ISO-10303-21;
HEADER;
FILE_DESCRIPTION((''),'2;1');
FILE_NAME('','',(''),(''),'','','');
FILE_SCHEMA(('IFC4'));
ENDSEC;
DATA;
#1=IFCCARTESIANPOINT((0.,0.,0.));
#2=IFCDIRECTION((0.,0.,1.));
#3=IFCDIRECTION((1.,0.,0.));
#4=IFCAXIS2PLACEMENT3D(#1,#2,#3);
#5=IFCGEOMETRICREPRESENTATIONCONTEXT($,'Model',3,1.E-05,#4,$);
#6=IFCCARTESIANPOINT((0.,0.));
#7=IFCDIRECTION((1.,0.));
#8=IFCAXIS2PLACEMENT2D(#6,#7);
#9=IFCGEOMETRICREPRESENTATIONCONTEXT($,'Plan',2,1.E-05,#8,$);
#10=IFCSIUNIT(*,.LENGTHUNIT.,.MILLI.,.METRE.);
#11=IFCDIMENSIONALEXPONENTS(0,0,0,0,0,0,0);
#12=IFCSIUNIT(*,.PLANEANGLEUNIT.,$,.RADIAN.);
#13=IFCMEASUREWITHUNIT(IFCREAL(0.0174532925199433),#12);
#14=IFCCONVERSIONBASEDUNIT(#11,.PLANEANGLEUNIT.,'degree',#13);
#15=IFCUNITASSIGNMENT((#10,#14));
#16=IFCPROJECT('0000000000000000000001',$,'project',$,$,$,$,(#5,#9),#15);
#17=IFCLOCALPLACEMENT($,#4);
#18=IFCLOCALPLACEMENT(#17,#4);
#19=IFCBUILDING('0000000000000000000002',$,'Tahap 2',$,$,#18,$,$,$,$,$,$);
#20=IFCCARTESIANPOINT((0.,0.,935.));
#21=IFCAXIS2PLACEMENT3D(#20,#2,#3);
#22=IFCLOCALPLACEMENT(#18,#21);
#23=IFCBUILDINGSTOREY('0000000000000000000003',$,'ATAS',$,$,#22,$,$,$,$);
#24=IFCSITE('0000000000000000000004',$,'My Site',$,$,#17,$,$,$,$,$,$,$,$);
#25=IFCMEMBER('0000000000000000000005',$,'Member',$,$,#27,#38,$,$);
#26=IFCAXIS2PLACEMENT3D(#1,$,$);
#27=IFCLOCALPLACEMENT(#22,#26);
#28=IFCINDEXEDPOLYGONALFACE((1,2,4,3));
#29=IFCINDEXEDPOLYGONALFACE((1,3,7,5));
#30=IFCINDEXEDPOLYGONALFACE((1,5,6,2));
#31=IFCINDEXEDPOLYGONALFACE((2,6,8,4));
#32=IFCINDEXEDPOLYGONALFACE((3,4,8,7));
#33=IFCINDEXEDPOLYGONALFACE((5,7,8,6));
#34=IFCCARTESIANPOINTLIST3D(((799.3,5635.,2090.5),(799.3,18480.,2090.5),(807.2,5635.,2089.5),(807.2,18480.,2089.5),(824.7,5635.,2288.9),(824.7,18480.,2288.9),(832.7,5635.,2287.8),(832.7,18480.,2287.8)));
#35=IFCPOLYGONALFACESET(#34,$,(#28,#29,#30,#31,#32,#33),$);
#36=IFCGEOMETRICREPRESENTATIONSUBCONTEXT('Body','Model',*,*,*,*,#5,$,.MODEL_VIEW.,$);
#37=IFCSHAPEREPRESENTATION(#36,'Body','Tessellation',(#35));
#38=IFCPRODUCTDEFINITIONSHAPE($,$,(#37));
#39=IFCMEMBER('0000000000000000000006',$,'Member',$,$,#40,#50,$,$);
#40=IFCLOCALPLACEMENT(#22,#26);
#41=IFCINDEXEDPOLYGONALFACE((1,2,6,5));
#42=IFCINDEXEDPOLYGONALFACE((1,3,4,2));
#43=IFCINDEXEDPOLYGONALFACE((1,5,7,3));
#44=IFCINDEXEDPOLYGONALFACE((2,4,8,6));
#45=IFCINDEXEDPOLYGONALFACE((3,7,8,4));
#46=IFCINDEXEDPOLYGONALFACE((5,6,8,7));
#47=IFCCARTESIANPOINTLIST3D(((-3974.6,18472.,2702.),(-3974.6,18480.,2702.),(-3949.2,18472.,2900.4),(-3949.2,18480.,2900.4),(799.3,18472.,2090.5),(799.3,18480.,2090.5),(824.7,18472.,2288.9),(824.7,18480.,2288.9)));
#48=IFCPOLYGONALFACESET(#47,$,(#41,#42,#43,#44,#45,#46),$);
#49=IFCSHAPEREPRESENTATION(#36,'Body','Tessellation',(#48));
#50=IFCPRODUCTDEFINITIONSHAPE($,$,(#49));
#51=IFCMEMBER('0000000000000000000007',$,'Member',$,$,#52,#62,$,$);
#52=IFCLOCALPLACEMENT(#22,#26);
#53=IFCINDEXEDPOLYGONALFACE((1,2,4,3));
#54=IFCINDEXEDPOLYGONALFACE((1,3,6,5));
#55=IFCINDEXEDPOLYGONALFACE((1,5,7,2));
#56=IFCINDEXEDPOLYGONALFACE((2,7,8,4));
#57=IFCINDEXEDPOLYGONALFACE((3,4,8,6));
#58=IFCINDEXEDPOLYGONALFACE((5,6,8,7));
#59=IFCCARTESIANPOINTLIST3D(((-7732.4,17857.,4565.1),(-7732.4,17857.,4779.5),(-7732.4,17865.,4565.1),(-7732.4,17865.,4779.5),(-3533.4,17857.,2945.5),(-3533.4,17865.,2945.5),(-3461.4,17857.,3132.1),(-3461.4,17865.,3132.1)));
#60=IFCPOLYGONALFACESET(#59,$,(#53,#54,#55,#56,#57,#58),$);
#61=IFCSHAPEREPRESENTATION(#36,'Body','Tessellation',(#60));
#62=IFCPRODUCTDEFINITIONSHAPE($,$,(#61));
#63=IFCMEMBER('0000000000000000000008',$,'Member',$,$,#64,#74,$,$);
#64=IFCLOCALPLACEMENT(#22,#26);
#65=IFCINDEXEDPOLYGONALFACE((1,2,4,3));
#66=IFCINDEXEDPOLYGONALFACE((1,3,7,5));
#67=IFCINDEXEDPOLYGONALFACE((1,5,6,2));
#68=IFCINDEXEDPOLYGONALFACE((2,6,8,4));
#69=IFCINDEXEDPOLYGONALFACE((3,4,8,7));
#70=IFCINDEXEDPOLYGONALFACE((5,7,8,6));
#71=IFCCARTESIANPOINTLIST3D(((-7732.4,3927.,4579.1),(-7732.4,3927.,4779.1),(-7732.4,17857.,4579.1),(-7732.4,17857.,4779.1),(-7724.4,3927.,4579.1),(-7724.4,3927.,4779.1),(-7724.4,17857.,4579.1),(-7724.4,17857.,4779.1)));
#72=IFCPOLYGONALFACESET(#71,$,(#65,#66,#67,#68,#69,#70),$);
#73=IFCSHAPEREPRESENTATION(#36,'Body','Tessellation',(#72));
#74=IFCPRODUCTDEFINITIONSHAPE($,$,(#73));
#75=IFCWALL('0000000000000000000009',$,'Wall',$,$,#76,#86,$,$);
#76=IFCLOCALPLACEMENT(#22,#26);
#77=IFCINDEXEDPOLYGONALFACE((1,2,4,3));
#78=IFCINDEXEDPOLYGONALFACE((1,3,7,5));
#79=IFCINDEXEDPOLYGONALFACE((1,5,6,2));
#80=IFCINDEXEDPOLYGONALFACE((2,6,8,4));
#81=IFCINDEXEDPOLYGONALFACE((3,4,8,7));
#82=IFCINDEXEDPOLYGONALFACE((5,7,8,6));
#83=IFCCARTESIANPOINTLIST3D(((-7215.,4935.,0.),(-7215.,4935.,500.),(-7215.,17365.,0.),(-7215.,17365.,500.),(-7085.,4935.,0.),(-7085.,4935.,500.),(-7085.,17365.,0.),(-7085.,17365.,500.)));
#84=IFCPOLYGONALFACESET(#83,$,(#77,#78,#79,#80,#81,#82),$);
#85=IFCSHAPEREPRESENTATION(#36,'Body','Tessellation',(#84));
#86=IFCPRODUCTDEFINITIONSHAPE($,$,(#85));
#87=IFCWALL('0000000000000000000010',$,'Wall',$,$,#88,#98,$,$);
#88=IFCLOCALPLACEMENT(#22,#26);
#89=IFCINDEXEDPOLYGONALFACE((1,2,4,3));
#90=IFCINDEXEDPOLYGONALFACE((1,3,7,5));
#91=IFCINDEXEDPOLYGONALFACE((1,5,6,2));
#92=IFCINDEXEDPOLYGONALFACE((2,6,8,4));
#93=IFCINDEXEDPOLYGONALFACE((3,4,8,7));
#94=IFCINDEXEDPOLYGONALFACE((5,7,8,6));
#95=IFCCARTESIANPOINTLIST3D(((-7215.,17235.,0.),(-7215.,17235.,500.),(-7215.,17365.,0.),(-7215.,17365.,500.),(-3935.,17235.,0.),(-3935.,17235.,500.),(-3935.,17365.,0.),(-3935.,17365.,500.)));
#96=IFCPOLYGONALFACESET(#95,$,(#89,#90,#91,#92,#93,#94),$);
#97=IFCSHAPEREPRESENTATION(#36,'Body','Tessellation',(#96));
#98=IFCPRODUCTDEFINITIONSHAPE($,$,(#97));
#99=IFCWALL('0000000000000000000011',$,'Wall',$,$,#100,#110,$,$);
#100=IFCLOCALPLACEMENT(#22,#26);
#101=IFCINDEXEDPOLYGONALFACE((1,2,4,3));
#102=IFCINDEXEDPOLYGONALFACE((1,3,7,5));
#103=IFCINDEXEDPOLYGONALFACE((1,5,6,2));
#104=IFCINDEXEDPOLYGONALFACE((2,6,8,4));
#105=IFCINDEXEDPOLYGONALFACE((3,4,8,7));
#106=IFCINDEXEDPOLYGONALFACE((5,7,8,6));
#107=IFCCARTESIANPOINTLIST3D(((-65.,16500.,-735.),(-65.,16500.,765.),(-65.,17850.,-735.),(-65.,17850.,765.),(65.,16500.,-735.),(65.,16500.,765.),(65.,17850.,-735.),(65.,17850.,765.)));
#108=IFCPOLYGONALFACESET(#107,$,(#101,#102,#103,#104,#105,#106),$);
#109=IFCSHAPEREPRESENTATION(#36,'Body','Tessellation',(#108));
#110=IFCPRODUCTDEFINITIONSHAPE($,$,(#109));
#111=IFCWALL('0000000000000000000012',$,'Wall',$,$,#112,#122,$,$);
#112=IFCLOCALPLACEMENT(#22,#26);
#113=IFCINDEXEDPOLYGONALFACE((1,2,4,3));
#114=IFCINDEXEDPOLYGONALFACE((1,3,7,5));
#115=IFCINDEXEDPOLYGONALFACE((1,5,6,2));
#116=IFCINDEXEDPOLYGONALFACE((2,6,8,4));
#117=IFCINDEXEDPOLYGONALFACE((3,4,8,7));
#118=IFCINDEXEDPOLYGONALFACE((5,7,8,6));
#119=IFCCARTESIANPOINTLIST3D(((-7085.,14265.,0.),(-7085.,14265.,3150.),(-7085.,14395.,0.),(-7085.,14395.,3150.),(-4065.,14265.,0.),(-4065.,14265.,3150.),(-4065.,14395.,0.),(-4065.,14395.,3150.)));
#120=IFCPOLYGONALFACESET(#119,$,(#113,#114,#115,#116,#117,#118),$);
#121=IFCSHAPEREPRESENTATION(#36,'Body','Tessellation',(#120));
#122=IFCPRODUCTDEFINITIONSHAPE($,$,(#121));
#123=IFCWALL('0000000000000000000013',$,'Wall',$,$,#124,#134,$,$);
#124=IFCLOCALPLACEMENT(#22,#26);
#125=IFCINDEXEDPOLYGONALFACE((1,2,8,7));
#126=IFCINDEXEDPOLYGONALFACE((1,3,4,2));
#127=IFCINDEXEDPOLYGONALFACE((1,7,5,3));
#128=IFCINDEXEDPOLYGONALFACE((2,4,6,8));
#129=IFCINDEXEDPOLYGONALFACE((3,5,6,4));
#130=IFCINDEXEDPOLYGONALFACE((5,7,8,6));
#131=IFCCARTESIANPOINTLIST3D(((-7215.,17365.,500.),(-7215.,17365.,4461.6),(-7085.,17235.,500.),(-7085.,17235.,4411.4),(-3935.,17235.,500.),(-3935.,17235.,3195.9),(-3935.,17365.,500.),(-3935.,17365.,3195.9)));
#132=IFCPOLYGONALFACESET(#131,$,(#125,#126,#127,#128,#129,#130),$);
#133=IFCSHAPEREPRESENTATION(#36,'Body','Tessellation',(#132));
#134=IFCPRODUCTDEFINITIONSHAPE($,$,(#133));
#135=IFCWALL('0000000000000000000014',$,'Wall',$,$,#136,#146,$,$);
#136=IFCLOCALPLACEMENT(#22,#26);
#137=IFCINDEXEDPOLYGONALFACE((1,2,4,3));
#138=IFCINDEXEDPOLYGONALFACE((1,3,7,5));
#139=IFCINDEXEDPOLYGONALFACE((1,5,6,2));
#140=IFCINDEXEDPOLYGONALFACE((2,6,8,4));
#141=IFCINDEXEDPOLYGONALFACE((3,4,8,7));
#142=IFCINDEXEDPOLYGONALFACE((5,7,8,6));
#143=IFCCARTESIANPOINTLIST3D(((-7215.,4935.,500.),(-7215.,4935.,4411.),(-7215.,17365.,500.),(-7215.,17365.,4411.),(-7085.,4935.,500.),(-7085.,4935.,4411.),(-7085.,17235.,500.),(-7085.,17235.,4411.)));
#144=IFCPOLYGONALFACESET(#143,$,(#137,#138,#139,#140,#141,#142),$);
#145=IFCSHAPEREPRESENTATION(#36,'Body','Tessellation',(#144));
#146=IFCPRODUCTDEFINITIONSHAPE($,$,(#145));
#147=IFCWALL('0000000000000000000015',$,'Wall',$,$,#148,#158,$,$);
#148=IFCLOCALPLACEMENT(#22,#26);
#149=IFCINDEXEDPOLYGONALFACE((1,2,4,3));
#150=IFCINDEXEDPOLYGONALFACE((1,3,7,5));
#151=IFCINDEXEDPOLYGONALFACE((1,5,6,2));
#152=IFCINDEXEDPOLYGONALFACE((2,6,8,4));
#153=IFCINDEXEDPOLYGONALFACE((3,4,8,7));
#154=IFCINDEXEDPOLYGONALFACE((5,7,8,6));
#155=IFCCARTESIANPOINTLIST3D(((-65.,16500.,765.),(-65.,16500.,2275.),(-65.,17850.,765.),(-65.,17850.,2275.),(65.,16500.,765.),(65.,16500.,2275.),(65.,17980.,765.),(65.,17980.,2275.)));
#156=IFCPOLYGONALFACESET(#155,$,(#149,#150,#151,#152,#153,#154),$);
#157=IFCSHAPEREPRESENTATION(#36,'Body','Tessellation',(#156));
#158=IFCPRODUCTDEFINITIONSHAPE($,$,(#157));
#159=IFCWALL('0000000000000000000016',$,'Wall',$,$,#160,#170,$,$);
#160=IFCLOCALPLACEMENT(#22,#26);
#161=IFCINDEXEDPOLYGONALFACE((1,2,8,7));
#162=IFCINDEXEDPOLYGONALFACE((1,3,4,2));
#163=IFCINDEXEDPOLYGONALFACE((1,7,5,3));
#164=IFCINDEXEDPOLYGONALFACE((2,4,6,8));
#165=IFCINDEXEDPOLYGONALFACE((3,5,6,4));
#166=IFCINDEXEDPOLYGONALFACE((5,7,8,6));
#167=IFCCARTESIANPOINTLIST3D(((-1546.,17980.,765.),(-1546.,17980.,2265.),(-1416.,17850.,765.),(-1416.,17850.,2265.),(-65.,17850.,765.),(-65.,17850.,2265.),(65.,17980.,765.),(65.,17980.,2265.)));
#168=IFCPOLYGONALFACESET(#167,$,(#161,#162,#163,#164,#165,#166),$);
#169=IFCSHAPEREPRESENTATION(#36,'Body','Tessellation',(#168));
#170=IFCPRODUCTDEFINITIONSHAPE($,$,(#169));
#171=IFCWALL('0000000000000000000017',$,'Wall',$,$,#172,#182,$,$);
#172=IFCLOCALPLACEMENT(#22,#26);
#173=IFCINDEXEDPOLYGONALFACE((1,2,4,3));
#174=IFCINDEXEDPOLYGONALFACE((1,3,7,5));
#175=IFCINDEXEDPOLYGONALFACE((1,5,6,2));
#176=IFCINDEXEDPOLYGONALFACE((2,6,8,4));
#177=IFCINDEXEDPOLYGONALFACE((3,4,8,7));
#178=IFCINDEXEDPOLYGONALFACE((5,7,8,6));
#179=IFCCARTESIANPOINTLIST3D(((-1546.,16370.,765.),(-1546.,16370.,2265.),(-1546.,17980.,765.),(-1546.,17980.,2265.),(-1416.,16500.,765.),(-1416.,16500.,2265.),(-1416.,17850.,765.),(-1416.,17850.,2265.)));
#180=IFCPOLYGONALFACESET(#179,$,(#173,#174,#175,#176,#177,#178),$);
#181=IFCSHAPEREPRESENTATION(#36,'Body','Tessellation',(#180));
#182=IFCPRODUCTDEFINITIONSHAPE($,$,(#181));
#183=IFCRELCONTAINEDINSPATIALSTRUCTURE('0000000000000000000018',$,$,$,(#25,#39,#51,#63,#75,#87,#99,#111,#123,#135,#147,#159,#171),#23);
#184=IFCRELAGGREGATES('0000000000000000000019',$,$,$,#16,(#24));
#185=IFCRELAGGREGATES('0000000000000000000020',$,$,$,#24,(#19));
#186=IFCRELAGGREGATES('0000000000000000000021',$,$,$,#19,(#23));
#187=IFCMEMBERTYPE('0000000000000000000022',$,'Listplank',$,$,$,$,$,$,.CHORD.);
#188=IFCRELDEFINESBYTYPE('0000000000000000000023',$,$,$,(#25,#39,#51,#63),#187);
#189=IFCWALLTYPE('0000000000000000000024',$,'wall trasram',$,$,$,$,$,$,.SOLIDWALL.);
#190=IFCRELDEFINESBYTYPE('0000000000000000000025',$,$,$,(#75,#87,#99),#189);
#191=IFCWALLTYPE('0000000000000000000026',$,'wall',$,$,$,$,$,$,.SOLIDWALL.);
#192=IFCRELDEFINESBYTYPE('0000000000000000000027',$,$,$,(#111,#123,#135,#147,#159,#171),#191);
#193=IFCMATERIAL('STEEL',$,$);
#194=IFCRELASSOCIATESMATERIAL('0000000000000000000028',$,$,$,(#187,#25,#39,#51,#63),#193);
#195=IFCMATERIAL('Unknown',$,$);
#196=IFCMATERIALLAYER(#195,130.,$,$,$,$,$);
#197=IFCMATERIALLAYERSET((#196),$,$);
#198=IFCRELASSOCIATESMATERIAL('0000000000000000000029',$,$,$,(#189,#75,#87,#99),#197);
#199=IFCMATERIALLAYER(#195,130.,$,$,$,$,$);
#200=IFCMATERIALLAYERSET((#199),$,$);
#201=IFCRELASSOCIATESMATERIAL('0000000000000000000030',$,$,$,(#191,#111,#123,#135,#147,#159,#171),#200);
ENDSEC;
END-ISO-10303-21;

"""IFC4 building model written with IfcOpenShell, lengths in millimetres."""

from ifc_helpers import new_model, entity, si_unit, converted_unit, frame, origin_with_axes, origin_2d_with_axis, place, context, subcontext, project, spatial, line, indexed_curve, rectangle, outline, extrude, clip, halfspace, material, layer, layer_set, layer_usage, material_profile, profile_set, profile_usage, type_object, element, save


model = new_model("IFC4")

# Units and contexts
model_context = context("Model", 3, precision=1e-05, world=origin_with_axes())
plan_context = context("Plan", 2, precision=1e-05, world=origin_2d_with_axis())
body_context_1 = subcontext(model_context, "Body", "Model", "MODEL_VIEW")
ifc_project = project(units=[si_unit("LENGTHUNIT", "METRE", prefix="MILLI"), converted_unit("PLANEANGLEUNIT", "degree", entity("IfcReal", 0.0174532925199433), si_unit("PLANEANGLEUNIT", "RADIAN"), dimensions=[0, 0, 0, 0, 0, 0, 0])], contexts=[model_context, plan_context])

# Site, building, storey
site_placement = place(None, origin_with_axes())
site = spatial("IfcSite", under=ifc_project, at=site_placement, Name="My Site")
building_placement = place(site_placement, origin_with_axes())
building = spatial("IfcBuilding", under=site, at=building_placement, Name="Tahap 2")
storey_placement = place(building_placement, frame((0.0, 0.0, 935.0), z_axis=(0.0, 0.0, 1.0), x_axis=(1.0, 0.0, 0.0)))
storey = spatial("IfcBuildingStorey", under=building, at=storey_placement, Name="ATAS")

# Members
ifc_material_1 = material(Name="STEEL")
ifc_material_profile = material_profile(ifc_material_1, rectangle(XDim=8.0, YDim=200.0, kind="CURVE"))
ifc_profile_set = profile_set([ifc_material_profile])
ifc_profile_usage_1 = profile_usage(ifc_profile_set, cardinal=9)
member_type = type_object("IfcMemberType", Name="Listplank", PredefinedType="CHORD", material=ifc_profile_set)
member_1_placement = place(storey_placement, frame((824.7, 18480.0, 2288.9), z_axis=(0.0, -1.0, 0.0), x_axis=(0.991894, 0.0, -0.127067)))
element("IfcMember", 1, at=member_1_placement, inside=storey, type_object=member_type, material=ifc_profile_usage_1, Name="Member", context=body_context_1, shape_type="SweptSolid", body=[
    extrude(rectangle(XDim=8.0, YDim=200.0, kind="CURVE"), frame((4.0, -100.0, 0.0), z_axis=(0.0, 0.0, 1.0), x_axis=(1.0, 0.0, 0.0)), (0.0, 0.0, 1.0), 12845.0),
])
ifc_profile_usage_2 = profile_usage(ifc_profile_set, cardinal=9)
member_2_placement = place(storey_placement, frame((824.7, 18480.0, 2288.9), z_axis=(-0.991894, 0.0, 0.127065), x_axis=(0.0, -1.0, 0.0)))
element("IfcMember", 2, at=member_2_placement, inside=storey, type_object=member_type, material=ifc_profile_usage_2, Name="Member", context=body_context_1, shape_type="SweptSolid", body=[
    extrude(rectangle(XDim=8.0, YDim=200.0, kind="CURVE"), frame((4.0, -100.0, 0.0), z_axis=(0.0, 0.0, 1.0), x_axis=(1.0, 0.0, 0.0)), (0.0, 0.0, 1.0), 4812.9),
])
ifc_profile_usage_3 = profile_usage(ifc_profile_set, cardinal=9)
member_3_placement = place(storey_placement, frame((-3461.4, 17865.0, 3132.1), z_axis=(-0.933001, 0.0, 0.359873), x_axis=(0.0, -1.0, 0.0)))
element("IfcMember", 3, at=member_3_placement, inside=storey, type_object=member_type, material=ifc_profile_usage_3, Name="Member", context=body_context_1, shape_type="Clipping", body=[
    clip(extrude(rectangle(XDim=8.0, YDim=200.0, kind="CURVE"), frame((4.0, -100.0, 0.0), z_axis=(0.0, 0.0, 1.0), x_axis=(1.0, 0.0, 0.0)), (0.0, 0.0, 1.0), 4777.7), halfspace(frame((0.0, -0.4, 4577.6), z_axis=(0.0, -0.359873, 0.933001), x_axis=(-1.0, 0.0, 0.0)), False)),
])
ifc_profile_usage_4 = profile_usage(ifc_profile_set, cardinal=9)
member_4_placement = place(storey_placement, frame((-7732.4, 17857.0, 4779.1), z_axis=(0.0, -1.0, 0.0), x_axis=(1.0, 0.0, 0.0)))
element("IfcMember", 4, at=member_4_placement, inside=storey, type_object=member_type, material=ifc_profile_usage_4, Name="Member", context=body_context_1, shape_type="SweptSolid", body=[
    extrude(rectangle(XDim=8.0, YDim=200.0, kind="CURVE"), frame((4.0, -100.0, 0.0), z_axis=(0.0, 0.0, 1.0), x_axis=(1.0, 0.0, 0.0)), (0.0, 0.0, 1.0), 13930.0),
])

# Walls
ifc_material_2 = material(Name="Unknown")
ifc_layer_1 = layer(ifc_material_2, 130.0)
ifc_layer_set_1 = layer_set([ifc_layer_1])
ifc_layer_usage_1 = layer_usage(ifc_layer_set_1, "AXIS2", "POSITIVE", 0.0)
wall_type_1 = type_object("IfcWallType", Name="wall trasram", PredefinedType="SOLIDWALL", material=ifc_layer_set_1)
wall_1_placement = place(storey_placement, frame((-7215.0, 17365.0, 0.0), z_axis=(0.0, 0.0, 1.0), x_axis=(0.0, -1.0, 0.0)))
element("IfcWall", 5, at=wall_1_placement, inside=storey, type_object=wall_type_1, material=ifc_layer_usage_1, Name="Wall", context=body_context_1, shape_type="SweptSolid", body=[
    extrude(outline(indexed_curve([(0.0, 0.0), (0.0, 130.0), (12430.0, 130.0), (12430.0, 0.0)], segments=[line(1, 2, 3, 4, 1)])), origin_with_axes(), (0.0, 0.0, 1.0), 500.0),
])
ifc_layer_usage_2 = layer_usage(ifc_layer_set_1, "AXIS2", "NEGATIVE", 0.0)
wall_2_placement = place(storey_placement, frame((-7215.0, 17365.0, 0.0), z_axis=(0.0, 0.0, 1.0), x_axis=(1.0, 0.0, 0.0)))
element("IfcWall", 6, at=wall_2_placement, inside=storey, type_object=wall_type_1, material=ifc_layer_usage_2, Name="Wall", context=body_context_1, shape_type="SweptSolid", body=[
    extrude(outline(indexed_curve([(0.0, -130.0), (0.0, 0.0), (3280.0, 0.0), (3280.0, -130.0)], segments=[line(1, 2, 3, 4, 1)])), origin_with_axes(), (0.0, 0.0, 1.0), 500.0),
])
ifc_layer_usage_3 = layer_usage(ifc_layer_set_1, "AXIS2", "POSITIVE", 0.0)
wall_3_placement = place(storey_placement, frame((65.0, 16500.0, -735.0), z_axis=(0.0, 0.0, 1.0), x_axis=(0.0, 1.0, 0.0)))
element("IfcWall", 7, at=wall_3_placement, inside=storey, type_object=wall_type_1, material=ifc_layer_usage_3, Name="Wall", context=body_context_1, shape_type="SweptSolid", body=[
    extrude(outline(indexed_curve([(0.0, 0.0), (0.0, 130.0), (1350.0, 130.0), (1350.0, 0.0)], segments=[line(1, 2, 3, 4, 1)])), origin_with_axes(), (0.0, 0.0, 1.0), 1500.0),
])
ifc_layer_2 = layer(ifc_material_2, 130.0)
ifc_layer_set_2 = layer_set([ifc_layer_2])
ifc_layer_usage_4 = layer_usage(ifc_layer_set_2, "AXIS2", "NEGATIVE", 0.0)
wall_type_2 = type_object("IfcWallType", Name="wall", PredefinedType="SOLIDWALL", material=ifc_layer_set_2)
wall_4_placement = place(storey_placement, frame((-4065.0, 14265.0, 0.0), z_axis=(0.0, 0.0, 1.0), x_axis=(-1.0, 0.0, 0.0)))
element("IfcWall", 8, at=wall_4_placement, inside=storey, type_object=wall_type_2, material=ifc_layer_usage_4, Name="Wall", context=body_context_1, shape_type="SweptSolid", body=[
    extrude(outline(indexed_curve([(0.0, -130.0), (0.0, 0.0), (3020.0, 0.0), (3020.0, -130.0)], segments=[line(1, 2, 3, 4, 1)])), origin_with_axes(), (0.0, 0.0, 1.0), 3150.0),
])
ifc_layer_usage_5 = layer_usage(ifc_layer_set_2, "AXIS2", "POSITIVE", 0.0)
wall_5_placement = place(storey_placement, frame((-3935.0, 17365.0, 500.0), z_axis=(0.0, 0.0, 1.0), x_axis=(-1.0, 0.0, 0.0)))
element("IfcWall", 9, at=wall_5_placement, inside=storey, type_object=wall_type_2, material=ifc_layer_usage_5, Name="Wall", context=body_context_1, shape_type="Clipping", body=[
    clip(extrude(outline(indexed_curve([(0.0, 0.0), (0.0, 130.0), (3150.0, 130.0), (3280.0, 0.0)], segments=[line(1, 2, 3, 4, 1)])), origin_with_axes(), (0.0, 0.0, 1.0), 5000.0), halfspace(frame((1516.1, 0.0, 3280.9), z_axis=(-0.359997, 0.0, 0.932954), x_axis=(-0.932954, 0.0, -0.359997)), False)),
])
ifc_layer_usage_6 = layer_usage(ifc_layer_set_2, "AXIS2", "POSITIVE", 0.0)
wall_6_placement = place(storey_placement, frame((-7215.0, 17365.0, 500.0), z_axis=(0.0, 0.0, 1.0), x_axis=(0.0, -1.0, 0.0)))
element("IfcWall", 10, at=wall_6_placement, inside=storey, type_object=wall_type_2, material=ifc_layer_usage_6, Name="Wall", context=body_context_1, shape_type="SweptSolid", body=[
    extrude(outline(indexed_curve([(0.0, 0.0), (130.0, 130.0), (12430.0, 130.0), (12430.0, 0.0)], segments=[line(1, 2, 3, 4, 1)])), origin_with_axes(), (0.0, 0.0, 1.0), 3911.0),
])
ifc_layer_usage_7 = layer_usage(ifc_layer_set_2, "AXIS2", "POSITIVE", 0.0)
wall_7_placement = place(storey_placement, frame((65.0, 16500.0, 765.0), z_axis=(0.0, 0.0, 1.0), x_axis=(0.0, 1.0, 0.0)))
element("IfcWall", 11, at=wall_7_placement, inside=storey, type_object=wall_type_2, material=ifc_layer_usage_7, Name="Wall", context=body_context_1, shape_type="SweptSolid", body=[
    extrude(outline(indexed_curve([(0.0, 0.0), (0.0, 130.0), (1350.0, 130.0), (1480.0, 0.0)], segments=[line(1, 2, 3, 4, 1)])), origin_with_axes(), (0.0, 0.0, 1.0), 1510.0),
])
ifc_layer_usage_8 = layer_usage(ifc_layer_set_2, "AXIS2", "POSITIVE", 0.0)
wall_8_placement = place(storey_placement, frame((65.0, 17980.0, 765.0), z_axis=(0.0, 0.0, 1.0), x_axis=(-1.0, -0.000001, 0.0)))
element("IfcWall", 12, at=wall_8_placement, inside=storey, type_object=wall_type_2, material=ifc_layer_usage_8, Name="Wall", context=body_context_1, shape_type="SweptSolid", body=[
    extrude(outline(indexed_curve([(0.0, 0.0), (130.0, 130.0), (1481.0, 130.0), (1611.0, 0.0)], segments=[line(1, 2, 3, 4, 1)])), origin_with_axes(), (0.0, 0.0, 1.0), 1500.0),
])
ifc_layer_usage_9 = layer_usage(ifc_layer_set_2, "AXIS2", "POSITIVE", 0.0)
wall_9_placement = place(storey_placement, frame((-1546.0, 17980.0, 765.0), z_axis=(0.0, 0.0, 1.0), x_axis=(0.0, -1.0, 0.0)))
element("IfcWall", 13, at=wall_9_placement, inside=storey, type_object=wall_type_2, material=ifc_layer_usage_9, Name="Wall", context=body_context_1, shape_type="SweptSolid", body=[
    extrude(outline(indexed_curve([(0.0, 0.0), (130.0, 130.0), (1480.0, 130.0), (1610.0, 0.0)], segments=[line(1, 2, 3, 4, 1)])), origin_with_axes(), (0.0, 0.0, 1.0), 1500.0),
])

save(model, "model.ifc")
